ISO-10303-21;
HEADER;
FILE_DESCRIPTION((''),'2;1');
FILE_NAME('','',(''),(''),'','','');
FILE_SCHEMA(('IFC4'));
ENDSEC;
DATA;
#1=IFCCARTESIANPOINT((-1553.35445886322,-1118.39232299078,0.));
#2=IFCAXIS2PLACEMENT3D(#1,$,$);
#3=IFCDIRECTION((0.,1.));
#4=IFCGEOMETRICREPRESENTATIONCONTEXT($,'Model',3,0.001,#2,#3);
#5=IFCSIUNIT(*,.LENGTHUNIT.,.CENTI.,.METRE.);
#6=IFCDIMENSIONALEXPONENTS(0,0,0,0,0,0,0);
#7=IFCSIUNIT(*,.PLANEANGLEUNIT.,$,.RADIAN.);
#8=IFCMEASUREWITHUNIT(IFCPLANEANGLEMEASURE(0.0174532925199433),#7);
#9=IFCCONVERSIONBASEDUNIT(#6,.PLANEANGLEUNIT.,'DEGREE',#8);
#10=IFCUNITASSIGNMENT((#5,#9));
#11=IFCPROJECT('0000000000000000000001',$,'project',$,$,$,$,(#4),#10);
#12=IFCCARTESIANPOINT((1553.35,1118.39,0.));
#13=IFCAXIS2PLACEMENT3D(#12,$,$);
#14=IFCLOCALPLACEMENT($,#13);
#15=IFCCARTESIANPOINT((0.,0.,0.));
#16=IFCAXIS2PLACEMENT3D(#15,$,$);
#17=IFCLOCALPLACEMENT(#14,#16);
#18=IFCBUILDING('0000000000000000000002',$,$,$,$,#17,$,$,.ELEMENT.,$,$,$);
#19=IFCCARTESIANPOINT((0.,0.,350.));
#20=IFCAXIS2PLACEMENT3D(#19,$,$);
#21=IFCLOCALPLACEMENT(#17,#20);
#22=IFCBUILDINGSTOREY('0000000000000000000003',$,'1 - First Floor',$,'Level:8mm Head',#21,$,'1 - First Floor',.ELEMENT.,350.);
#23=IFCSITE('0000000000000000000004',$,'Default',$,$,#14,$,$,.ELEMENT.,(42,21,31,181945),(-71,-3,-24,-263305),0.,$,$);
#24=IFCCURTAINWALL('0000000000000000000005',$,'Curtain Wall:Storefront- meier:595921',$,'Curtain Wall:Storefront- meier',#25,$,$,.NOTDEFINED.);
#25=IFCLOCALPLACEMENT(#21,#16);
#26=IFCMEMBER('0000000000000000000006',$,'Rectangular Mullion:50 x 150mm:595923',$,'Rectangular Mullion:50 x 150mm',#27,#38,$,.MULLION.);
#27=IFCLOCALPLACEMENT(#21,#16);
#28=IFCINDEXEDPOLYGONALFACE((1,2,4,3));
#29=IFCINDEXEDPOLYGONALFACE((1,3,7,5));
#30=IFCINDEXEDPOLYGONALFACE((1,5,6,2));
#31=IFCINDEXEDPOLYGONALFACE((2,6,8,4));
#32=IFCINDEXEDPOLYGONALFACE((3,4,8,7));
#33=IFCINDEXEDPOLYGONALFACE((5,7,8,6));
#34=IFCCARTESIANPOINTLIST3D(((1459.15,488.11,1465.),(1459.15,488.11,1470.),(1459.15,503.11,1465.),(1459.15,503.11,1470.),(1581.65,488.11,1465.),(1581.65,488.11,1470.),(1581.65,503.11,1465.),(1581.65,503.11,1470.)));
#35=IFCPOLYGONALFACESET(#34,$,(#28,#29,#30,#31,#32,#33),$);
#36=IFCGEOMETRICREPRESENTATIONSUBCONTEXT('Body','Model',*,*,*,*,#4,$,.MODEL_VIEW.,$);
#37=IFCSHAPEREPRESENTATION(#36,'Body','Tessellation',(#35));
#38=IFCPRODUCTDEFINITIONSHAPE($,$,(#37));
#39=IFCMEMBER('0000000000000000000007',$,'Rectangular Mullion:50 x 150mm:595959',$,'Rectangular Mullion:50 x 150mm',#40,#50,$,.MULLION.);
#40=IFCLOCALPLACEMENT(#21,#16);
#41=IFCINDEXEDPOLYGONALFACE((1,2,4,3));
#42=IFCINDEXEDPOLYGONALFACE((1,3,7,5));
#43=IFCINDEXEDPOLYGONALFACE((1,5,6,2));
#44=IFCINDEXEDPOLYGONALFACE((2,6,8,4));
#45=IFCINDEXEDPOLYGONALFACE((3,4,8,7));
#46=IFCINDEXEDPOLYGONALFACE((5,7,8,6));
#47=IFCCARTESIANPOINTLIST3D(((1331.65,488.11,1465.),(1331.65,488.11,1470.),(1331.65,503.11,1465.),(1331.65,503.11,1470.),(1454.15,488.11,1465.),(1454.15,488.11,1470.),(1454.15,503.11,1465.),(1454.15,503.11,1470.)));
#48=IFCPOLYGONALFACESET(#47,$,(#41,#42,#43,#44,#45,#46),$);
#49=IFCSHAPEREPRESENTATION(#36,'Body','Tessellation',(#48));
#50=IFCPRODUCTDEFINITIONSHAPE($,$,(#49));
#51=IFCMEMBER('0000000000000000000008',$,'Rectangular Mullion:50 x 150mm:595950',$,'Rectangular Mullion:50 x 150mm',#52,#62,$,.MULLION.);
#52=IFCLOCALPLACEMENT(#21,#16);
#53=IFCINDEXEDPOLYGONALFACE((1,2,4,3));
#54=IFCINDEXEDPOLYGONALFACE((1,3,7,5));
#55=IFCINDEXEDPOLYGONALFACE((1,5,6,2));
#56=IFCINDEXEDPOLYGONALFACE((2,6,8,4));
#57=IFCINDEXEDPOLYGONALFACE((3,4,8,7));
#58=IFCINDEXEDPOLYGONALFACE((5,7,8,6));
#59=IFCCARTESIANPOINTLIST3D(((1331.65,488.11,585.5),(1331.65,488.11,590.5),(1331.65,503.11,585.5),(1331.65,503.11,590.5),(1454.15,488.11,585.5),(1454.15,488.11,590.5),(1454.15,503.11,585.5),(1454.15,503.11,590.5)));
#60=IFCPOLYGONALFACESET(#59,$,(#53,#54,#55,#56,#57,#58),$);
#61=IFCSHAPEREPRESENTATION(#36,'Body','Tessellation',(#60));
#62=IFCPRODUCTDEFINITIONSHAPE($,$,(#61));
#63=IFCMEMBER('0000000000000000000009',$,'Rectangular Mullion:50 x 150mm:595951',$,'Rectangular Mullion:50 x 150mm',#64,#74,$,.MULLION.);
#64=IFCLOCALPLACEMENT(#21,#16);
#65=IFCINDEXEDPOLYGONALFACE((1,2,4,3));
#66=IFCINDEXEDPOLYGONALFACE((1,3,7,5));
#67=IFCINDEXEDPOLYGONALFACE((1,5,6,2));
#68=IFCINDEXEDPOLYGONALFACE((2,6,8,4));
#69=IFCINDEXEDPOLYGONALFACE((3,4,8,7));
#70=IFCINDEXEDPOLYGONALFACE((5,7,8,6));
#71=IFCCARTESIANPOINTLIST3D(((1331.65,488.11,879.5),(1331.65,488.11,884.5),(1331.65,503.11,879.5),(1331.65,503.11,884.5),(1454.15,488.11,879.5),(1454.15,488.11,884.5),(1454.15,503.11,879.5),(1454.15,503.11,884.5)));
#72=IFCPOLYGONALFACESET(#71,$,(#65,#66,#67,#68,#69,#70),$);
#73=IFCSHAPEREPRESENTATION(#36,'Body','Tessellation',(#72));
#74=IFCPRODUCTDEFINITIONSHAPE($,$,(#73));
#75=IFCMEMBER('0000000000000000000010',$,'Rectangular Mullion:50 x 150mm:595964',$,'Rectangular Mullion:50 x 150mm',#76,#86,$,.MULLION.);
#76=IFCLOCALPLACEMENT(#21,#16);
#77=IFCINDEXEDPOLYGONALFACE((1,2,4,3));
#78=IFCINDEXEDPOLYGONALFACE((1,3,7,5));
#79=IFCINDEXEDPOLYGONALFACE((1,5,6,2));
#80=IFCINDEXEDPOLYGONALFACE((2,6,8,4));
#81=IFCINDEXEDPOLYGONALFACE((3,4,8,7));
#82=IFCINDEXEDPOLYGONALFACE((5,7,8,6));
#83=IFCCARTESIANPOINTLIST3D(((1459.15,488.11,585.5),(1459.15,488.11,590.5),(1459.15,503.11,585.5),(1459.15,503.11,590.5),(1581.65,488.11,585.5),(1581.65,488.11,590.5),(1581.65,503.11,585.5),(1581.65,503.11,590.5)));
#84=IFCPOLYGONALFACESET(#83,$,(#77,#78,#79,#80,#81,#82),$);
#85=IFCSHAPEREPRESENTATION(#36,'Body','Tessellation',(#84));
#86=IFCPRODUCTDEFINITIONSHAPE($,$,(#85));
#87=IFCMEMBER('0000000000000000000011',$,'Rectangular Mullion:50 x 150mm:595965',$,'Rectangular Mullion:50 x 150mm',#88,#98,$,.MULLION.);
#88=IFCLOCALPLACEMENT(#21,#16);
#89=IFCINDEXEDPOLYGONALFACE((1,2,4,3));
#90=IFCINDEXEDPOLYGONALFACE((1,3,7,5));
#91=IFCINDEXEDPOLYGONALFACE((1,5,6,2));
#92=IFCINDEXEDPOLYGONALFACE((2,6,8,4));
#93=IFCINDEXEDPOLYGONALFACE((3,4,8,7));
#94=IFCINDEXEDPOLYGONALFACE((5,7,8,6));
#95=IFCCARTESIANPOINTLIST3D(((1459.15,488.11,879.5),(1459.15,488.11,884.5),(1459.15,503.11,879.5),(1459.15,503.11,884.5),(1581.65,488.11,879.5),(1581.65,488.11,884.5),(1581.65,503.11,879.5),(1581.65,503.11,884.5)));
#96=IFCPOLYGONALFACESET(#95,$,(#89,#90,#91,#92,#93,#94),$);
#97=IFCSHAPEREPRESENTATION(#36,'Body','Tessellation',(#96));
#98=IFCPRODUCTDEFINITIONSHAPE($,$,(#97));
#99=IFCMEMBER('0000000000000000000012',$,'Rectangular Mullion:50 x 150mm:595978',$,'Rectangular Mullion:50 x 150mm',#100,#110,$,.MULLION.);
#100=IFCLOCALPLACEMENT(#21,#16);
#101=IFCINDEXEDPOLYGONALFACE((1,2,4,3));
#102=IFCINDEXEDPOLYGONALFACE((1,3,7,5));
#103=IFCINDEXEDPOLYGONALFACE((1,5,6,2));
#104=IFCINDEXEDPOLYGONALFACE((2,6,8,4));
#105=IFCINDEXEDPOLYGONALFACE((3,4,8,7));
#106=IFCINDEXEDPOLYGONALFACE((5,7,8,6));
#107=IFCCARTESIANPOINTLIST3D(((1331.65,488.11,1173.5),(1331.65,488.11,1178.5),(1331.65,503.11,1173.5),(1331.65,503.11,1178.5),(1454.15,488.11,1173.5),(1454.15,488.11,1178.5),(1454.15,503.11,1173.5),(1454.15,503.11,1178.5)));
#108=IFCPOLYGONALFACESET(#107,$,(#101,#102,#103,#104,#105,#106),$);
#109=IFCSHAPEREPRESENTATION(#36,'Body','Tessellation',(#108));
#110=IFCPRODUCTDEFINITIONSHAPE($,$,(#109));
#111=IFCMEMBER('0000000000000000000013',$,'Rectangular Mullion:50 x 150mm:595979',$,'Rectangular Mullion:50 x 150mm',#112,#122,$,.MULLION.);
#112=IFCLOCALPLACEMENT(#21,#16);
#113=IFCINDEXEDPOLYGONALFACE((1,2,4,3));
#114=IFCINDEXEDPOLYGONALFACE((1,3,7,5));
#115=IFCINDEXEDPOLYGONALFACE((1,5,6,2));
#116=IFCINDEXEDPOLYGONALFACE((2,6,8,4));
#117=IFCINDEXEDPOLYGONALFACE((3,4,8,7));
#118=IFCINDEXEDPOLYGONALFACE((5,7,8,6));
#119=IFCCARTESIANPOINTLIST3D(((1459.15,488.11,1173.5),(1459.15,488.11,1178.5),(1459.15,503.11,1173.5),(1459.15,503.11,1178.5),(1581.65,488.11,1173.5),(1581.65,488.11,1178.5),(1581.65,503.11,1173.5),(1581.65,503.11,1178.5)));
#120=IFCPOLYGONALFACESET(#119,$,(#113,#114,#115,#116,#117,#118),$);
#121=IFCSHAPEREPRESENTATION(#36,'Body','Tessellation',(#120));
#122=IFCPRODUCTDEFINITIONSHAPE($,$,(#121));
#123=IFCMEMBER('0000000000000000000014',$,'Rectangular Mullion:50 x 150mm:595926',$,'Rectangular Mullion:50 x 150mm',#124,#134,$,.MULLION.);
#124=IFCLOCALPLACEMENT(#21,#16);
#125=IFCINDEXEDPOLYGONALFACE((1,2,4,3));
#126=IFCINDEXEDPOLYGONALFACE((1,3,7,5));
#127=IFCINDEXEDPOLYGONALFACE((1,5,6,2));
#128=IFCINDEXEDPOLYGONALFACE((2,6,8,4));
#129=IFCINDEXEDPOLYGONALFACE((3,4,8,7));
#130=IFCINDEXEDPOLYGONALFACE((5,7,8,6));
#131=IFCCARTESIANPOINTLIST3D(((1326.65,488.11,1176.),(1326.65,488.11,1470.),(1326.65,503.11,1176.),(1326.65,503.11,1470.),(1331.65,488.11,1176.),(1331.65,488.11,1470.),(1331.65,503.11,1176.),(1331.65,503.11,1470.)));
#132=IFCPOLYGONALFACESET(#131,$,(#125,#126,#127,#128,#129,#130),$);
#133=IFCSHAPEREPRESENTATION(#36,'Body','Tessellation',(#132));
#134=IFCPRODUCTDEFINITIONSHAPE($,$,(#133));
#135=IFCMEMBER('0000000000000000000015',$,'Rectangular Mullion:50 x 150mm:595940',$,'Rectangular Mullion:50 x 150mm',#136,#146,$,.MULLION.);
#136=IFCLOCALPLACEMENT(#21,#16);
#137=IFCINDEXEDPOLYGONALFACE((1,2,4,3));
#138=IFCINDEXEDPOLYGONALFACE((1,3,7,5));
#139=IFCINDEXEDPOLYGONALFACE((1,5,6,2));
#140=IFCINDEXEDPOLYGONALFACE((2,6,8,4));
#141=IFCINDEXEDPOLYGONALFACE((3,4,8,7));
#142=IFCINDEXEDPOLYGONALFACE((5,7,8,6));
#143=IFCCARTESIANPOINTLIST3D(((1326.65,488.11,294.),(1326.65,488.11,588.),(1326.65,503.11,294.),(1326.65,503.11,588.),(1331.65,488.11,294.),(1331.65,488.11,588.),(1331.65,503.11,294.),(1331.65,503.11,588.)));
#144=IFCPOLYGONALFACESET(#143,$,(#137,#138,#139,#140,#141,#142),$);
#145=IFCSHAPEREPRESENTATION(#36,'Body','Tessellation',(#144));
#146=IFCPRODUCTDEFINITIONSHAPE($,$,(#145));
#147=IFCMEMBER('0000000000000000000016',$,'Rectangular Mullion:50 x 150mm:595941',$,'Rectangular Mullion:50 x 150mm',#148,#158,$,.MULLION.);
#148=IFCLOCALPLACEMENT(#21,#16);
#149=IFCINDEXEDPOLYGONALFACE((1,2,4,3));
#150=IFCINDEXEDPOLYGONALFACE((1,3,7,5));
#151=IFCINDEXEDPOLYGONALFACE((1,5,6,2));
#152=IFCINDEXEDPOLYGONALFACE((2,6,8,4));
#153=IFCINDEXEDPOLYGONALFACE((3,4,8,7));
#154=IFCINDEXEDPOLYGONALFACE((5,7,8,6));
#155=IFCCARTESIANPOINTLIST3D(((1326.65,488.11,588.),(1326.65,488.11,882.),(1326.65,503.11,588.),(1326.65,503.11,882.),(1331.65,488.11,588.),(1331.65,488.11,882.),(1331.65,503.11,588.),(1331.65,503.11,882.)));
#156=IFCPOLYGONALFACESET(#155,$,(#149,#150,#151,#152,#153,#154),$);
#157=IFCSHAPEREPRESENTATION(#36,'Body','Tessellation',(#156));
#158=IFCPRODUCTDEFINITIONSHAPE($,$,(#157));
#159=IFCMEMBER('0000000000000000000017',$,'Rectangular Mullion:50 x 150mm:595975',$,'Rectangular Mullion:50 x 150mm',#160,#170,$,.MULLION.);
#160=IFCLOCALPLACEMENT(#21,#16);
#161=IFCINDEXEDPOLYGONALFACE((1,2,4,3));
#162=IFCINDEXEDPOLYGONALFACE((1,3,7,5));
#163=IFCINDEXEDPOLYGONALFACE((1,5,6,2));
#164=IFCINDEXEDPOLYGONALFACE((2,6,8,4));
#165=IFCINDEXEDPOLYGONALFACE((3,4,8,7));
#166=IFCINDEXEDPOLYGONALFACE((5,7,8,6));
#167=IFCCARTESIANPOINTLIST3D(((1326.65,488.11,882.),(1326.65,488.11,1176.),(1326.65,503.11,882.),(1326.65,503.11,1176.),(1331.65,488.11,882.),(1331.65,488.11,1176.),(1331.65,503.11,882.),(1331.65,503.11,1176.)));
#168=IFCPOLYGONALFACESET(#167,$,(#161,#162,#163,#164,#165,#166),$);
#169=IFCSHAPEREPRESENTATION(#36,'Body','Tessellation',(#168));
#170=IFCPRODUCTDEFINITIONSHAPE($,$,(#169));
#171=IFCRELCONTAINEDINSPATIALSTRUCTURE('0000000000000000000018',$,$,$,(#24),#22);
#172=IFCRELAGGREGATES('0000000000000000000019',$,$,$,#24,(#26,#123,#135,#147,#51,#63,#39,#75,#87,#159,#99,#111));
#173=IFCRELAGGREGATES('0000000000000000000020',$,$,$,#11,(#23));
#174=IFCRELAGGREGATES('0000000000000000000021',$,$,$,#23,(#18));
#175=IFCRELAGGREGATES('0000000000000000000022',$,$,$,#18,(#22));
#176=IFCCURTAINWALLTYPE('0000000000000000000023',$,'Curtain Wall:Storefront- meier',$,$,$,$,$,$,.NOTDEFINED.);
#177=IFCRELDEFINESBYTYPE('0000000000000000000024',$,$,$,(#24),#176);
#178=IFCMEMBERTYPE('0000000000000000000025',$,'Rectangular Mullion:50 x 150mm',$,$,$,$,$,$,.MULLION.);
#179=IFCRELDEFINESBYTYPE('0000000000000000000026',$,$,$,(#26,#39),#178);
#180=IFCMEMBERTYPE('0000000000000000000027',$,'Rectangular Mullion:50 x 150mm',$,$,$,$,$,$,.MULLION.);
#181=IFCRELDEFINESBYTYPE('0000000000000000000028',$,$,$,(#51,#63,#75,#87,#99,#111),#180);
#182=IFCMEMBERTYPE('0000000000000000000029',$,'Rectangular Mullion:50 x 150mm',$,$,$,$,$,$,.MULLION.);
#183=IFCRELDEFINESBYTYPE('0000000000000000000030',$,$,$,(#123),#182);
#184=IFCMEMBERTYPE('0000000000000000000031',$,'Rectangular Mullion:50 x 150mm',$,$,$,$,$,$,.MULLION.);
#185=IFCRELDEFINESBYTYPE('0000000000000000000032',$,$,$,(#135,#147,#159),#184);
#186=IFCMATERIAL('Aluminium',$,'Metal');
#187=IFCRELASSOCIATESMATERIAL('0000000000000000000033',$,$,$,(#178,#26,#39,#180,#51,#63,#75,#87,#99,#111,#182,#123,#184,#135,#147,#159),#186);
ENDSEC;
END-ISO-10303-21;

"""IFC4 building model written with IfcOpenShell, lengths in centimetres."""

from ifc_helpers import new_model, entity, si_unit, converted_unit, direction, frame, origin, place, context, subcontext, project, spatial, indexed_curve, outline, extrude, source, transform, mapped, material, type_object, type_shapes, element, aggregate, save


model = new_model("IFC4")

# Units and contexts
model_context = context("Model", 3, precision=0.001, world=frame((-1553.35445886322, -1118.39232299078, 0.0)), true_north=direction((0.0, 1.0)))
body_context = subcontext(model_context, "Body", "Model", "MODEL_VIEW")
ifc_project = project(units=[si_unit("LENGTHUNIT", "METRE", prefix="CENTI"), converted_unit("PLANEANGLEUNIT", "DEGREE", entity("IfcPlaneAngleMeasure", 0.0174532925199433), si_unit("PLANEANGLEUNIT", "RADIAN"), dimensions=[0, 0, 0, 0, 0, 0, 0])], contexts=[model_context])

# Site, building, storey
site_placement = place(None, frame((1553.35, 1118.39, 0.0)))
site = spatial("IfcSite", under=ifc_project, at=site_placement, Name="Default", CompositionType="ELEMENT", RefLatitude=(42, 21, 31, 181945), RefLongitude=(-71, -3, -24, -263305), RefElevation=0.0)
building_placement = place(site_placement, origin())
building = spatial("IfcBuilding", under=site, at=building_placement, CompositionType="ELEMENT")
storey_placement = place(building_placement, frame((0.0, 0.0, 350.0)))
storey = spatial("IfcBuildingStorey", under=building, at=storey_placement, Name="1 - First Floor", ObjectType="Level:8mm Head", LongName="1 - First Floor", CompositionType="ELEMENT", Elevation=350.0)

# Curtain wall, members
curtain_wall_type = type_object("IfcCurtainWallType", Name="Curtain Wall:Storefront- meier", PredefinedType="NOTDEFINED")
curtain_wall_placement = place(storey_placement, frame((0.0, 0.0, -350.0)))
curtain_wall = element("IfcCurtainWall", 1, at=curtain_wall_placement, inside=storey, type_object=curtain_wall_type, Name="Curtain Wall:Storefront- meier:595921", ObjectType="Curtain Wall:Storefront- meier", PredefinedType="NOTDEFINED")
ifc_material_1 = material(Name="Aluminium", Category="Metal")
member_type_1 = type_object("IfcMemberType", Name="Rectangular Mullion:50 x 150mm", PredefinedType="MULLION", material=ifc_material_1)
shared_shape_1 = source(origin(), body_context, "Body", "SweptSolid", [
    extrude(outline(indexed_curve([(-2.5, -7.5), (2.5, -7.5), (2.5, 7.5), (-2.5, 7.5), (-2.5, -7.5)], self_intersect=False)), frame((-2.5, 0.0, -122.5), z_axis=(0.0, 0.0, 1.0), x_axis=(-1.0, 0.0, 0.0)), (0.0, 0.0, 1.0), 122.5),
])
type_shapes(member_type_1, [shared_shape_1])
member_1_placement = place(curtain_wall_placement, frame((1581.65, 495.61, 1820.0), z_axis=(1.0, 0.0, 0.0), x_axis=(0.0, 0.0, 1.0)))
member_1 = element("IfcMember", 2, at=member_1_placement, type_object=member_type_1, material=ifc_material_1, Name="Rectangular Mullion:50 x 150mm:595923", ObjectType="Rectangular Mullion:50 x 150mm", PredefinedType="MULLION", context=body_context, shape_type="MappedRepresentation", body=[
    mapped(shared_shape_1, transform((0.0, 0.0, 0.0), scale=1.0)),
])
member_2_placement = place(curtain_wall_placement, frame((1454.15, 495.61, 1820.0), z_axis=(1.0, 0.0, 0.0), x_axis=(0.0, 0.0, 1.0)))
member_2 = element("IfcMember", 3, at=member_2_placement, type_object=member_type_1, material=ifc_material_1, Name="Rectangular Mullion:50 x 150mm:595959", ObjectType="Rectangular Mullion:50 x 150mm", PredefinedType="MULLION", context=body_context, shape_type="MappedRepresentation", body=[
    mapped(shared_shape_1, transform((0.0, 0.0, 0.0), scale=1.0)),
])
member_type_2 = type_object("IfcMemberType", Name="Rectangular Mullion:50 x 150mm", PredefinedType="MULLION", material=ifc_material_1)
shared_shape_2 = source(origin(), body_context, "Body", "SweptSolid", [
    extrude(outline(indexed_curve([(-2.5, -7.5), (2.5, -7.5), (2.5, 7.5), (-2.5, 7.5), (-2.5, -7.5)], self_intersect=False)), frame((0.0, 0.0, -122.5), z_axis=(0.0, 0.0, 1.0), x_axis=(-1.0, 0.0, 0.0)), (0.0, 0.0, 1.0), 122.5),
])
type_shapes(member_type_2, [shared_shape_2])
member_3_placement = place(curtain_wall_placement, frame((1454.15, 495.61, 938.0), z_axis=(1.0, 0.0, 0.0), x_axis=(0.0, 0.0, 1.0)))
member_3 = element("IfcMember", 4, at=member_3_placement, type_object=member_type_2, material=ifc_material_1, Name="Rectangular Mullion:50 x 150mm:595950", ObjectType="Rectangular Mullion:50 x 150mm", PredefinedType="MULLION", context=body_context, shape_type="MappedRepresentation", body=[
    mapped(shared_shape_2, transform((0.0, 0.0, 0.0), scale=1.0)),
])
member_4_placement = place(curtain_wall_placement, frame((1454.15, 495.61, 1232.0), z_axis=(1.0, 0.0, 0.0), x_axis=(0.0, 0.0, 1.0)))
member_4 = element("IfcMember", 5, at=member_4_placement, type_object=member_type_2, material=ifc_material_1, Name="Rectangular Mullion:50 x 150mm:595951", ObjectType="Rectangular Mullion:50 x 150mm", PredefinedType="MULLION", context=body_context, shape_type="MappedRepresentation", body=[
    mapped(shared_shape_2, transform((0.0, 0.0, 0.0), scale=1.0)),
])
member_5_placement = place(curtain_wall_placement, frame((1581.65, 495.61, 938.0), z_axis=(1.0, 0.0, 0.0), x_axis=(0.0, 0.0, 1.0)))
member_5 = element("IfcMember", 6, at=member_5_placement, type_object=member_type_2, material=ifc_material_1, Name="Rectangular Mullion:50 x 150mm:595964", ObjectType="Rectangular Mullion:50 x 150mm", PredefinedType="MULLION", context=body_context, shape_type="MappedRepresentation", body=[
    mapped(shared_shape_2, transform((0.0, 0.0, 0.0), scale=1.0)),
])
member_6_placement = place(curtain_wall_placement, frame((1581.65, 495.61, 1232.0), z_axis=(1.0, 0.0, 0.0), x_axis=(0.0, 0.0, 1.0)))
member_6 = element("IfcMember", 7, at=member_6_placement, type_object=member_type_2, material=ifc_material_1, Name="Rectangular Mullion:50 x 150mm:595965", ObjectType="Rectangular Mullion:50 x 150mm", PredefinedType="MULLION", context=body_context, shape_type="MappedRepresentation", body=[
    mapped(shared_shape_2, transform((0.0, 0.0, 0.0), scale=1.0)),
])
member_7_placement = place(curtain_wall_placement, frame((1454.15, 495.61, 1526.0), z_axis=(1.0, 0.0, 0.0), x_axis=(0.0, 0.0, 1.0)))
member_7 = element("IfcMember", 8, at=member_7_placement, type_object=member_type_2, material=ifc_material_1, Name="Rectangular Mullion:50 x 150mm:595978", ObjectType="Rectangular Mullion:50 x 150mm", PredefinedType="MULLION", context=body_context, shape_type="MappedRepresentation", body=[
    mapped(shared_shape_2, transform((0.0, 0.0, 0.0), scale=1.0)),
])
member_8_placement = place(curtain_wall_placement, frame((1581.65, 495.61, 1526.0), z_axis=(1.0, 0.0, 0.0), x_axis=(0.0, 0.0, 1.0)))
member_8 = element("IfcMember", 9, at=member_8_placement, type_object=member_type_2, material=ifc_material_1, Name="Rectangular Mullion:50 x 150mm:595979", ObjectType="Rectangular Mullion:50 x 150mm", PredefinedType="MULLION", context=body_context, shape_type="MappedRepresentation", body=[
    mapped(shared_shape_2, transform((0.0, 0.0, 0.0), scale=1.0)),
])
member_type_3 = type_object("IfcMemberType", Name="Rectangular Mullion:50 x 150mm", PredefinedType="MULLION", material=ifc_material_1)
shared_shape_3 = source(origin(), body_context, "Body", "SweptSolid", [
    extrude(outline(indexed_curve([(-2.5, -7.5), (2.5, -7.5), (2.5, 7.5), (-2.5, 7.5), (-2.5, -7.5)], self_intersect=False)), frame((-2.5, 0.0, -294.0), z_axis=(0.0, 0.0, 1.0), x_axis=(-1.0, 0.0, 0.0)), (0.0, 0.0, 1.0), 294.0),
])
type_shapes(member_type_3, [shared_shape_3])
member_9_placement = place(curtain_wall_placement, frame((1326.65, 495.61, 1820.0), z_axis=(0.0, 0.0, 1.0), x_axis=(-1.0, 0.0, 0.0)))
member_9 = element("IfcMember", 10, at=member_9_placement, type_object=member_type_3, material=ifc_material_1, Name="Rectangular Mullion:50 x 150mm:595926", ObjectType="Rectangular Mullion:50 x 150mm", PredefinedType="MULLION", context=body_context, shape_type="MappedRepresentation", body=[
    mapped(shared_shape_3, transform((0.0, 0.0, 0.0), scale=1.0)),
])
member_type_4 = type_object("IfcMemberType", Name="Rectangular Mullion:50 x 150mm", PredefinedType="MULLION", material=ifc_material_1)
shared_shape_4 = source(origin(), body_context, "Body", "SweptSolid", [
    extrude(outline(indexed_curve([(-2.5, -7.5), (2.5, -7.5), (2.5, 7.5), (-2.5, 7.5), (-2.5, -7.5)], self_intersect=False)), frame((-2.5, 0.0, -294.0), z_axis=(0.0, 0.0, 1.0), x_axis=(-1.0, 0.0, 0.0)), (0.0, 0.0, 1.0), 294.0),
])
type_shapes(member_type_4, [shared_shape_4])
member_10_placement = place(curtain_wall_placement, frame((1326.65, 495.61, 938.0), z_axis=(0.0, 0.0, 1.0), x_axis=(-1.0, 0.0, 0.0)))
member_10 = element("IfcMember", 11, at=member_10_placement, type_object=member_type_4, material=ifc_material_1, Name="Rectangular Mullion:50 x 150mm:595940", ObjectType="Rectangular Mullion:50 x 150mm", PredefinedType="MULLION", context=body_context, shape_type="MappedRepresentation", body=[
    mapped(shared_shape_4, transform((0.0, 0.0, 0.0), scale=1.0)),
])
member_11_placement = place(curtain_wall_placement, frame((1326.65, 495.61, 1232.0), z_axis=(0.0, 0.0, 1.0), x_axis=(-1.0, 0.0, 0.0)))
member_11 = element("IfcMember", 12, at=member_11_placement, type_object=member_type_4, material=ifc_material_1, Name="Rectangular Mullion:50 x 150mm:595941", ObjectType="Rectangular Mullion:50 x 150mm", PredefinedType="MULLION", context=body_context, shape_type="MappedRepresentation", body=[
    mapped(shared_shape_4, transform((0.0, 0.0, 0.0), scale=1.0)),
])
member_12_placement = place(curtain_wall_placement, frame((1326.65, 495.61, 1526.0), z_axis=(0.0, 0.0, 1.0), x_axis=(-1.0, 0.0, 0.0)))
member_12 = element("IfcMember", 13, at=member_12_placement, type_object=member_type_4, material=ifc_material_1, Name="Rectangular Mullion:50 x 150mm:595975", ObjectType="Rectangular Mullion:50 x 150mm", PredefinedType="MULLION", context=body_context, shape_type="MappedRepresentation", body=[
    mapped(shared_shape_4, transform((0.0, 0.0, 0.0), scale=1.0)),
])
aggregate(curtain_wall, [member_1, member_9, member_10, member_11, member_3, member_4, member_2, member_5, member_6, member_12, member_7, member_8])

save(model, "model.ifc")
